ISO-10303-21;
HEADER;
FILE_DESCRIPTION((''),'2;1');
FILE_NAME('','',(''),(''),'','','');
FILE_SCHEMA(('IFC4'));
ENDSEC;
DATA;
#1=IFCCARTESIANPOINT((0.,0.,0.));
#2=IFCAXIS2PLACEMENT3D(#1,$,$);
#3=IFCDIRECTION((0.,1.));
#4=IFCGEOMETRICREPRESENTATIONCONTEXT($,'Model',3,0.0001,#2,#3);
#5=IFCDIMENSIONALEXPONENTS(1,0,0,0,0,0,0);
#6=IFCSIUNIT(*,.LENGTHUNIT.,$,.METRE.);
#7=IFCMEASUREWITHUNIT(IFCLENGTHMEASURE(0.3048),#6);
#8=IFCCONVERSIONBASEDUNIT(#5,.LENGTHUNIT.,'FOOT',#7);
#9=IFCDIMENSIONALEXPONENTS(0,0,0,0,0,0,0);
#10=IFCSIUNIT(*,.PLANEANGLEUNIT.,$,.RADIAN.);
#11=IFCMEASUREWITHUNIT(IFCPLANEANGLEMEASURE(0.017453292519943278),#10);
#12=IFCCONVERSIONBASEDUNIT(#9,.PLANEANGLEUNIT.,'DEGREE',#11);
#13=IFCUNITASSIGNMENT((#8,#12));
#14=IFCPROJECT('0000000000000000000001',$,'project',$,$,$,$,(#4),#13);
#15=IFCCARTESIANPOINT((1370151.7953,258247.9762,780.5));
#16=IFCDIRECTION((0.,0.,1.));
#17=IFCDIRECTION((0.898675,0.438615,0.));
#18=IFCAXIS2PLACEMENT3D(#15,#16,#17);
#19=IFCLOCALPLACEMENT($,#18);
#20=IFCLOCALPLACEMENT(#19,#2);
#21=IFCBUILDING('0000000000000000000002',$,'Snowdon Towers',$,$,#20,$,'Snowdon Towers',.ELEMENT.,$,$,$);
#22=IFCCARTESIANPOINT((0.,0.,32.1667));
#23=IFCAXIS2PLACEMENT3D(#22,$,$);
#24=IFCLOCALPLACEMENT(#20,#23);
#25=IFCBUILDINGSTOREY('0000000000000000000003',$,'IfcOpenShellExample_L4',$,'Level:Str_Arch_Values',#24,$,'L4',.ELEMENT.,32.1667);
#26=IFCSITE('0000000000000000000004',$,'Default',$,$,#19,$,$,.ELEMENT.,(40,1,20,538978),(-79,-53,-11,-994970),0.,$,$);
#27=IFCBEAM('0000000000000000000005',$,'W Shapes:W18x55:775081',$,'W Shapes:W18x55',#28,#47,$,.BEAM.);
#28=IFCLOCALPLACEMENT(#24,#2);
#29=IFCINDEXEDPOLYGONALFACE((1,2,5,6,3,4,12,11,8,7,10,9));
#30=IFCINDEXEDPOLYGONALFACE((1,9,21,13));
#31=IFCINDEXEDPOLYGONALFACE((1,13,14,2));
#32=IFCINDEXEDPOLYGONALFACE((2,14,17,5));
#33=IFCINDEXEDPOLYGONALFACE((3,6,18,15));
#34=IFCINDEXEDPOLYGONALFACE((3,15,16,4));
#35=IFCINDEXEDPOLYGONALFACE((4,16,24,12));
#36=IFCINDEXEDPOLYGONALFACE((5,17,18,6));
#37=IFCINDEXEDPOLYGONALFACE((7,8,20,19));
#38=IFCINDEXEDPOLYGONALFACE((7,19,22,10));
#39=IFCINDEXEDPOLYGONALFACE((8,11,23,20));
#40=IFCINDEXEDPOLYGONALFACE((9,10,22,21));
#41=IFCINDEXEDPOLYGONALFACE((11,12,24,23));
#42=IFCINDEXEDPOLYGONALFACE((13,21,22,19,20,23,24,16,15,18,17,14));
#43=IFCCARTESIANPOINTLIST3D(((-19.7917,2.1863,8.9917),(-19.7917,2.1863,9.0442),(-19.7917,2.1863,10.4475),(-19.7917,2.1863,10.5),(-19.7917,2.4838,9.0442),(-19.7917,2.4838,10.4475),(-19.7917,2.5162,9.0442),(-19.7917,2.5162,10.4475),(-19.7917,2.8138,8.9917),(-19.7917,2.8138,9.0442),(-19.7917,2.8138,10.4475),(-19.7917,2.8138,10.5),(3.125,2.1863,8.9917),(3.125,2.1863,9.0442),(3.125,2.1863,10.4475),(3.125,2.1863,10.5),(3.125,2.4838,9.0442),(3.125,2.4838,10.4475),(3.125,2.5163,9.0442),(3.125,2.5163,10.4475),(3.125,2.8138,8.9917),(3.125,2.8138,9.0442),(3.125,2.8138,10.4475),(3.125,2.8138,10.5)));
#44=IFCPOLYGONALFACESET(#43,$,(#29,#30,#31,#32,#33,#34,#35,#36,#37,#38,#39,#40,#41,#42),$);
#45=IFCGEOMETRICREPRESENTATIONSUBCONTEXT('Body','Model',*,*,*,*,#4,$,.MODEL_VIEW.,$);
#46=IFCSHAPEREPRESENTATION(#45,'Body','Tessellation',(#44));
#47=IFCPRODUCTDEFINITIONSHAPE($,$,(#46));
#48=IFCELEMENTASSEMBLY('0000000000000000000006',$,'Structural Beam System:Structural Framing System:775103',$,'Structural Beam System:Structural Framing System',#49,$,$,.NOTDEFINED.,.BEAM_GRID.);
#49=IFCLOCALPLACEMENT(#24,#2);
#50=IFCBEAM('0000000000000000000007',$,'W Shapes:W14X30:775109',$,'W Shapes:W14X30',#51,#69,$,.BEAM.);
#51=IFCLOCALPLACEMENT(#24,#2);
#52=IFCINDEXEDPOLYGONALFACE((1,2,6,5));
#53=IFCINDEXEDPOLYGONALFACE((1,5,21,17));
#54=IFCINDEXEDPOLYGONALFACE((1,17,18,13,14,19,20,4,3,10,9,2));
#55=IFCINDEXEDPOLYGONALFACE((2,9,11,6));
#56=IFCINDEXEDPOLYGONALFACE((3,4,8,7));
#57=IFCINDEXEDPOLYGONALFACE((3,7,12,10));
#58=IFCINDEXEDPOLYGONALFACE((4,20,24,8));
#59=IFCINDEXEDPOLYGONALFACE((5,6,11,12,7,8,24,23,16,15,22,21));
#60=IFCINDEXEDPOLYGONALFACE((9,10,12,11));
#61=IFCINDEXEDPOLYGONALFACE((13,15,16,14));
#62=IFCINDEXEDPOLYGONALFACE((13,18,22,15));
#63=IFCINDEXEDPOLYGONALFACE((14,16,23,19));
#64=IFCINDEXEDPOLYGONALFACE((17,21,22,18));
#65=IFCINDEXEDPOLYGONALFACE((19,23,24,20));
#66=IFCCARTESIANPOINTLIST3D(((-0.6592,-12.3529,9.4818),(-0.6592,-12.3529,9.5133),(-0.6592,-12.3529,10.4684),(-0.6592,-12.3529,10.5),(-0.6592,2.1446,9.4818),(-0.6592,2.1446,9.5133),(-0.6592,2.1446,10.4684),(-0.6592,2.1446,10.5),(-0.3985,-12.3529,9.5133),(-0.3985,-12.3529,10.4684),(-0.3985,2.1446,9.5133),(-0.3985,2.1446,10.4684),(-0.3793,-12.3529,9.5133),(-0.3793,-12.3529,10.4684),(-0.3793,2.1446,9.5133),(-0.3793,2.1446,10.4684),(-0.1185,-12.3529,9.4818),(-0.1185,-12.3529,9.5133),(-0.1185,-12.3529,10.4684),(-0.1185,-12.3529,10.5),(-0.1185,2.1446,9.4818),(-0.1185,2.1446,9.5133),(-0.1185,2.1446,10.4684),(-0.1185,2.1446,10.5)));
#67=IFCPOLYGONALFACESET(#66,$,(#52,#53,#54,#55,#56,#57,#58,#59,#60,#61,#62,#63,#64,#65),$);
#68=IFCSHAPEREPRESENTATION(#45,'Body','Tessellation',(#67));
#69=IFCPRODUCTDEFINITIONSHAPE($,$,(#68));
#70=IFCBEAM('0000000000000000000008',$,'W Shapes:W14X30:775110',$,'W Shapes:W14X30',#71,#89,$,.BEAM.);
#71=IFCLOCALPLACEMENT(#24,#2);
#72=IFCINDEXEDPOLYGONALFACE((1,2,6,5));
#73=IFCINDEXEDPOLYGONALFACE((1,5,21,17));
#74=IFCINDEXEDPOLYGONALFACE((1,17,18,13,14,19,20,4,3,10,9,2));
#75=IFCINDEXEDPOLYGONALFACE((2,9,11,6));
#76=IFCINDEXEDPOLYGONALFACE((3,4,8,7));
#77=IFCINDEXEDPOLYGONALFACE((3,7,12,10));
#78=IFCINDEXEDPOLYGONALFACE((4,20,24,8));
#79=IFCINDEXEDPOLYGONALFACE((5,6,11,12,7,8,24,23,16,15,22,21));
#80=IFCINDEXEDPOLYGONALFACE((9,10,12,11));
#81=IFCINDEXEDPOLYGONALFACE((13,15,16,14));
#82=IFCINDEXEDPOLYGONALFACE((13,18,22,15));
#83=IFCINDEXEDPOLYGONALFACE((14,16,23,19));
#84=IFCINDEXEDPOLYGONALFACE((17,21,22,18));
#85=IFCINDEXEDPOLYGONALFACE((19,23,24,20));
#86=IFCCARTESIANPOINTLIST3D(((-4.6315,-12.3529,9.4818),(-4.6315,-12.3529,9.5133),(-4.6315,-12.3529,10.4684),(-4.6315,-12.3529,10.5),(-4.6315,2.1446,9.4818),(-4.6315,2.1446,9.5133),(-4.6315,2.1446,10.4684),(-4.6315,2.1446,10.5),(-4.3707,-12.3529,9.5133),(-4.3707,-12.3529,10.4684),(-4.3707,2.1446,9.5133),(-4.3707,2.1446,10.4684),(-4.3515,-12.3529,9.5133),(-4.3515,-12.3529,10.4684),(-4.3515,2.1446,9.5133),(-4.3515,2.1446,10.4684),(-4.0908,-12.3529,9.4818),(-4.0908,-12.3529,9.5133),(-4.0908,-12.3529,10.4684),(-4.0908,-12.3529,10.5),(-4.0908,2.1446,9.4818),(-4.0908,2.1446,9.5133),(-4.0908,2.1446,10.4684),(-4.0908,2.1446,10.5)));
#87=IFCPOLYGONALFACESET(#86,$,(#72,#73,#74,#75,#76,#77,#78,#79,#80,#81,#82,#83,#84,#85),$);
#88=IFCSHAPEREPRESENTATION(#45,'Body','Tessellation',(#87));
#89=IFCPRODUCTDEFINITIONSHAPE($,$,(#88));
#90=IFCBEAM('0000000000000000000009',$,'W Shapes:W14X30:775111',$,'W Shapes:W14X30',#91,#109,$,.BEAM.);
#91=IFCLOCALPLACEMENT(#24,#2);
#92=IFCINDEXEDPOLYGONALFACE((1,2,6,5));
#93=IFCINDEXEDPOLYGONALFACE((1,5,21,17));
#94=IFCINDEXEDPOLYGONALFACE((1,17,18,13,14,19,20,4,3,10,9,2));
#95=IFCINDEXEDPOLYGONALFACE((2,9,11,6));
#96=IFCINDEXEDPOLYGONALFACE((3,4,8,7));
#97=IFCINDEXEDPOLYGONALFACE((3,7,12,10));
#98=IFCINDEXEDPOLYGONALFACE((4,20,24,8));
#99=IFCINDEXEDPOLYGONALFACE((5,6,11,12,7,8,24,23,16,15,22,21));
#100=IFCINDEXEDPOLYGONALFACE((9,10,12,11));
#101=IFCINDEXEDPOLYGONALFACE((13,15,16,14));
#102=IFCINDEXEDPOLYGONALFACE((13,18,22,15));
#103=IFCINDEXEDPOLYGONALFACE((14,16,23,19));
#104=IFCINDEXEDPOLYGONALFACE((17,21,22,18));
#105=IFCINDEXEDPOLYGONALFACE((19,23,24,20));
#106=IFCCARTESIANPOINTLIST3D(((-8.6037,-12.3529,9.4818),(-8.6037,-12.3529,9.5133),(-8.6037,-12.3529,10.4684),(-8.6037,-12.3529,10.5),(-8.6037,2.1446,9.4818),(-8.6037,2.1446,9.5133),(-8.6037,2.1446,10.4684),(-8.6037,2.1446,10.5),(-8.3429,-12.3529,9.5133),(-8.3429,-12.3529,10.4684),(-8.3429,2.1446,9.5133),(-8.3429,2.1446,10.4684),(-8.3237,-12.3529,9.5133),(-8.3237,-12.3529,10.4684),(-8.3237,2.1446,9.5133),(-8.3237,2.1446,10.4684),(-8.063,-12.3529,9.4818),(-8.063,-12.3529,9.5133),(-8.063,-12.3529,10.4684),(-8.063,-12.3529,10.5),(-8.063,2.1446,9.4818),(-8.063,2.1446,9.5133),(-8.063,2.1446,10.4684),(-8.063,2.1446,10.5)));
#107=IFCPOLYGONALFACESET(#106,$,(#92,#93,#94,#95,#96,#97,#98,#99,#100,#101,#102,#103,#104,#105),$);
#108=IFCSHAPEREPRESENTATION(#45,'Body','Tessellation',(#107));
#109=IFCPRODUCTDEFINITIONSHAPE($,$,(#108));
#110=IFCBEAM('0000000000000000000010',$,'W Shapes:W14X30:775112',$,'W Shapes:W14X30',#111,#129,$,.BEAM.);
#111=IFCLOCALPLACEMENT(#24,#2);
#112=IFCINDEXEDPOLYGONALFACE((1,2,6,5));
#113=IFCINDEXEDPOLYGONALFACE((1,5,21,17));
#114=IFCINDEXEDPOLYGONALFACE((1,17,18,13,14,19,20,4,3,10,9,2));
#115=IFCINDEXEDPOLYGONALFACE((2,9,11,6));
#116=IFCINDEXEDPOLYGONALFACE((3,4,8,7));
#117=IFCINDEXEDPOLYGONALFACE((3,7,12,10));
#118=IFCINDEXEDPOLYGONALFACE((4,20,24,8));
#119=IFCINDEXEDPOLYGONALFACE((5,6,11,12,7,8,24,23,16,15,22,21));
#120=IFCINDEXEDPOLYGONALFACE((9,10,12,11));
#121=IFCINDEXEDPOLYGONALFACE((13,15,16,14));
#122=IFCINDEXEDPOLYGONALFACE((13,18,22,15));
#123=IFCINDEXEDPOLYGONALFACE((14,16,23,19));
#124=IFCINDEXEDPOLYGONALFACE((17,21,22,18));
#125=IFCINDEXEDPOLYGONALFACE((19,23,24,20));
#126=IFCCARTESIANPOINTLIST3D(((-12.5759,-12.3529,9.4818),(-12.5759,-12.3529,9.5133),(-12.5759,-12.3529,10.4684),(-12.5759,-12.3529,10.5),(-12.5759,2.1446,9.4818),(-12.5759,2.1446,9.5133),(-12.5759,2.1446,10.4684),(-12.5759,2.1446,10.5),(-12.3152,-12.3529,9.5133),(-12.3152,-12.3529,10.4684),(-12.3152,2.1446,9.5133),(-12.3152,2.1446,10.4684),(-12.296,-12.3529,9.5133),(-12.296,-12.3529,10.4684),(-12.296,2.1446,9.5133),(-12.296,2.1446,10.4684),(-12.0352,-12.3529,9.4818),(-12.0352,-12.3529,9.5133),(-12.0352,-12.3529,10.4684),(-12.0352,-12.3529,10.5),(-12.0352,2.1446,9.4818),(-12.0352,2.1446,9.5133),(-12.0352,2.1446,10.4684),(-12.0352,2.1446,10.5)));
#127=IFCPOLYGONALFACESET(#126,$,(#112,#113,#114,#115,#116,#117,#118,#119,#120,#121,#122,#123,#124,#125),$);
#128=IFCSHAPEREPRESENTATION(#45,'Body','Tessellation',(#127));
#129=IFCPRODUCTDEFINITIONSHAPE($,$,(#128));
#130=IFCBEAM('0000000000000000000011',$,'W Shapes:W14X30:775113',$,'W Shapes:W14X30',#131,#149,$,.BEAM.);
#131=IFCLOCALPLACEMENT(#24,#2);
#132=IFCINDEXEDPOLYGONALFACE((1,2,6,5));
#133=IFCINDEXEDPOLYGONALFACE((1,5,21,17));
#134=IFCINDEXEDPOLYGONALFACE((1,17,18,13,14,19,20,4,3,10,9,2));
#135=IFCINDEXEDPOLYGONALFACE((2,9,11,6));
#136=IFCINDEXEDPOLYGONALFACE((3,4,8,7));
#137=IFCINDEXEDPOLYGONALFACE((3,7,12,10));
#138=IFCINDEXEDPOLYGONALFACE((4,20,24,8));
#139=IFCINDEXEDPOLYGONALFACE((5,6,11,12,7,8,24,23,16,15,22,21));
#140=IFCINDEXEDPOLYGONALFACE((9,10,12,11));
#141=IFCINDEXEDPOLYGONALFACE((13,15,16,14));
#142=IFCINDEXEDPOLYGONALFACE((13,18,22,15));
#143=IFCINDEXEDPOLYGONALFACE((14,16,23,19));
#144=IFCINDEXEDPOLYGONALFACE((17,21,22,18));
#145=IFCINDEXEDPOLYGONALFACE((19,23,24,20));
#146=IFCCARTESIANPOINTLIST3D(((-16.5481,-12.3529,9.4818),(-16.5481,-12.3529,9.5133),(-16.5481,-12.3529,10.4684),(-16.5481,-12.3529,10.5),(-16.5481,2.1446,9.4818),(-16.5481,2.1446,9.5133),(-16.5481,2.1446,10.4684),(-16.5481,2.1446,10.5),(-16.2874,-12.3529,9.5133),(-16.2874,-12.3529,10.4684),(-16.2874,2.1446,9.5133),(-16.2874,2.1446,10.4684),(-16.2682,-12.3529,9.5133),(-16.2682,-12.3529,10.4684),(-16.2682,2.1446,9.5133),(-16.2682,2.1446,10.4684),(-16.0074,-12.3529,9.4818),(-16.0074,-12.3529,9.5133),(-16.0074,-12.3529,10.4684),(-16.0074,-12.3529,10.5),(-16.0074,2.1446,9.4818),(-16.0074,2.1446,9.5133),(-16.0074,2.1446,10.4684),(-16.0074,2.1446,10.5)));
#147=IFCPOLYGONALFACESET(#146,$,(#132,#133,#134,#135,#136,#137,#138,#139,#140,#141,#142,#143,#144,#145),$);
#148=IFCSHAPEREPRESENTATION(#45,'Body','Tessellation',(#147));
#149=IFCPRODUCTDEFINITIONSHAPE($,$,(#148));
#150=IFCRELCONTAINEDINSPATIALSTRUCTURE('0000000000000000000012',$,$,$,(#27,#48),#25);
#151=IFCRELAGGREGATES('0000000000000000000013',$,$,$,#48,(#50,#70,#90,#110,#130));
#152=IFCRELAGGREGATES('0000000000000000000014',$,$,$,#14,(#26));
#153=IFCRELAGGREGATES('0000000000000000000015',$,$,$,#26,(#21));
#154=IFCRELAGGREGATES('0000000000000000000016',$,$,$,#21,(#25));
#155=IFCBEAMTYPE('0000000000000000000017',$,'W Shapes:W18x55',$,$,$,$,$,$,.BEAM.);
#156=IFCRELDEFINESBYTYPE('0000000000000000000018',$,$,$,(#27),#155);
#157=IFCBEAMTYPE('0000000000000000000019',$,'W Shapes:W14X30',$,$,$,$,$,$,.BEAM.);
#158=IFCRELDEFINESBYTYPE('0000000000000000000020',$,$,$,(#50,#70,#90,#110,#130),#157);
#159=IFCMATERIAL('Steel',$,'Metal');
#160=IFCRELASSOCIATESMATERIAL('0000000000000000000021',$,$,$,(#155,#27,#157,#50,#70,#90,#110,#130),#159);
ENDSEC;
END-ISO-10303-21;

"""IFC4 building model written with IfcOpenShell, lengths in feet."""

from ifc_helpers import new_model, entity, si_unit, converted_unit, direction, frame, origin, place, context, subcontext, project, spatial, indexed_curve, outline, extrude, source, transform, mapped, material, type_object, type_shapes, element, aggregate, save


model = new_model("IFC4")

# Units and contexts
model_context = context("Model", 3, precision=0.0001, world=origin(), true_north=direction((0.0, 1.0)))
body_context = subcontext(model_context, "Body", "Model", "MODEL_VIEW")
ifc_project = project(units=[converted_unit("LENGTHUNIT", "FOOT", entity("IfcLengthMeasure", 0.3048), si_unit("LENGTHUNIT", "METRE"), dimensions=[1, 0, 0, 0, 0, 0, 0]), converted_unit("PLANEANGLEUNIT", "DEGREE", entity("IfcPlaneAngleMeasure", 0.017453292519943278), si_unit("PLANEANGLEUNIT", "RADIAN"), dimensions=[0, 0, 0, 0, 0, 0, 0])], contexts=[model_context])

# Site, building, storey
site_placement = place(None, frame((1370151.7953, 258247.9762, 780.5), z_axis=(0.0, 0.0, 1.0), x_axis=(0.898675, 0.438615, 0.0)))
site = spatial("IfcSite", under=ifc_project, at=site_placement, Name="Default", CompositionType="ELEMENT", RefLatitude=(40, 1, 20, 538978), RefLongitude=(-79, -53, -11, -994970), RefElevation=0.0)
building_placement = place(site_placement, origin())
building = spatial("IfcBuilding", under=site, at=building_placement, Name="Snowdon Towers", LongName="Snowdon Towers", CompositionType="ELEMENT")
storey_placement = place(building_placement, frame((0.0, 0.0, 32.1667)))
storey = spatial("IfcBuildingStorey", under=building, at=storey_placement, Name="IfcOpenShellExample_L4", ObjectType="Level:Str_Arch_Values", LongName="L4", CompositionType="ELEMENT", Elevation=32.1667)

# Shared definitions
ifc_material_1 = material(Name="Steel", Category="Metal")

# Beam
beam_type_1 = type_object("IfcBeamType", Name="W Shapes:W18x55", PredefinedType="BEAM", material=ifc_material_1)
shared_shape_1 = source(origin(), body_context, "Body", "SweptSolid", [
    extrude(outline(indexed_curve([(-0.3138, -0.7017), (-0.3138, -0.7542), (0.3138, -0.7542), (0.3138, -0.7017), (0.0162, -0.7017), (0.0162, 0.7017), (0.3138, 0.7017), (0.3138, 0.7542), (-0.3137, 0.7542), (-0.3137, 0.7017), (-0.0163, 0.7017), (-0.0163, -0.7017), (-0.3138, -0.7017)], self_intersect=False)), frame((-11.4583, 0.0, 0.0), z_axis=(-1.0, 0.0, 0.0), x_axis=(0.0, -1.0, 0.0)), (0.0, 0.0, -1.0), 22.9167),
])
type_shapes(beam_type_1, [shared_shape_1])
beam_1_placement = place(storey_placement, frame((-8.3333, 2.5, 9.7458)))
element("IfcBeam", 1, at=beam_1_placement, inside=storey, type_object=beam_type_1, material=ifc_material_1, Name="W Shapes:W18x55:775081", ObjectType="W Shapes:W18x55", PredefinedType="BEAM", context=body_context, shape_type="MappedRepresentation", body=[
    mapped(shared_shape_1, transform((0.0, 0.0, 0.0), scale=1.0)),
])

# Element assembly, beams
assembly_1_placement = place(storey_placement, origin())
assembly_1 = element("IfcElementAssembly", 2, at=assembly_1_placement, inside=storey, Name="Structural Beam System:Structural Framing System:775103", ObjectType="Structural Beam System:Structural Framing System", AssemblyPlace="NOTDEFINED", PredefinedType="BEAM_GRID")
beam_type_2 = type_object("IfcBeamType", Name="W Shapes:W14X30", PredefinedType="BEAM", material=ifc_material_1)
shared_shape_2 = source(origin(), body_context, "Body", "SweptSolid", [
    extrude(outline(indexed_curve([(-0.2703, -0.4775), (-0.2703, -0.5091), (0.2703, -0.5091), (0.2703, -0.4775), (0.0096, -0.4775), (0.0096, 0.4775), (0.2703, 0.4775), (0.2703, 0.5091), (-0.2703, 0.5091), (-0.2703, 0.4775), (-0.0096, 0.4775), (-0.0096, -0.4775), (-0.2703, -0.4775)], self_intersect=False)), frame((-7.2487, 0.0, 0.0), z_axis=(-1.0, 0.0, 0.0), x_axis=(0.0, -1.0, 0.0)), (0.0, 0.0, -1.0), 14.4975),
])
type_shapes(beam_type_2, [shared_shape_2])
beam_2_placement = place(assembly_1_placement, frame((-0.3889, -5.1042, 9.9909), z_axis=(0.0, 0.0, 1.0), x_axis=(0.0, -1.0, 0.0)))
beam_2 = element("IfcBeam", 3, at=beam_2_placement, type_object=beam_type_2, material=ifc_material_1, Name="W Shapes:W14X30:775109", ObjectType="W Shapes:W14X30", PredefinedType="BEAM", context=body_context, shape_type="MappedRepresentation", body=[
    mapped(shared_shape_2, transform((0.0, 0.0, 0.0), scale=1.0)),
])
beam_3_placement = place(assembly_1_placement, frame((-4.3611, -5.1042, 9.9909), z_axis=(0.0, 0.0, 1.0), x_axis=(0.0, -1.0, 0.0)))
beam_3 = element("IfcBeam", 4, at=beam_3_placement, type_object=beam_type_2, material=ifc_material_1, Name="W Shapes:W14X30:775110", ObjectType="W Shapes:W14X30", PredefinedType="BEAM", context=body_context, shape_type="MappedRepresentation", body=[
    mapped(shared_shape_2, transform((0.0, 0.0, 0.0), scale=1.0)),
])
beam_4_placement = place(assembly_1_placement, frame((-8.3333, -5.1042, 9.9909), z_axis=(0.0, 0.0, 1.0), x_axis=(0.0, -1.0, 0.0)))
beam_4 = element("IfcBeam", 5, at=beam_4_placement, type_object=beam_type_2, material=ifc_material_1, Name="W Shapes:W14X30:775111", ObjectType="W Shapes:W14X30", PredefinedType="BEAM", context=body_context, shape_type="MappedRepresentation", body=[
    mapped(shared_shape_2, transform((0.0, 0.0, 0.0), scale=1.0)),
])
beam_5_placement = place(assembly_1_placement, frame((-12.3056, -5.1042, 9.9909), z_axis=(0.0, 0.0, 1.0), x_axis=(0.0, -1.0, 0.0)))
beam_5 = element("IfcBeam", 6, at=beam_5_placement, type_object=beam_type_2, material=ifc_material_1, Name="W Shapes:W14X30:775112", ObjectType="W Shapes:W14X30", PredefinedType="BEAM", context=body_context, shape_type="MappedRepresentation", body=[
    mapped(shared_shape_2, transform((0.0, 0.0, 0.0), scale=1.0)),
])
beam_6_placement = place(assembly_1_placement, frame((-16.2778, -5.1042, 9.9909), z_axis=(0.0, 0.0, 1.0), x_axis=(0.0, -1.0, 0.0)))
beam_6 = element("IfcBeam", 7, at=beam_6_placement, type_object=beam_type_2, material=ifc_material_1, Name="W Shapes:W14X30:775113", ObjectType="W Shapes:W14X30", PredefinedType="BEAM", context=body_context, shape_type="MappedRepresentation", body=[
    mapped(shared_shape_2, transform((0.0, 0.0, 0.0), scale=1.0)),
])
aggregate(assembly_1, [beam_2, beam_3, beam_4, beam_5, beam_6])

save(model, "model.ifc")
